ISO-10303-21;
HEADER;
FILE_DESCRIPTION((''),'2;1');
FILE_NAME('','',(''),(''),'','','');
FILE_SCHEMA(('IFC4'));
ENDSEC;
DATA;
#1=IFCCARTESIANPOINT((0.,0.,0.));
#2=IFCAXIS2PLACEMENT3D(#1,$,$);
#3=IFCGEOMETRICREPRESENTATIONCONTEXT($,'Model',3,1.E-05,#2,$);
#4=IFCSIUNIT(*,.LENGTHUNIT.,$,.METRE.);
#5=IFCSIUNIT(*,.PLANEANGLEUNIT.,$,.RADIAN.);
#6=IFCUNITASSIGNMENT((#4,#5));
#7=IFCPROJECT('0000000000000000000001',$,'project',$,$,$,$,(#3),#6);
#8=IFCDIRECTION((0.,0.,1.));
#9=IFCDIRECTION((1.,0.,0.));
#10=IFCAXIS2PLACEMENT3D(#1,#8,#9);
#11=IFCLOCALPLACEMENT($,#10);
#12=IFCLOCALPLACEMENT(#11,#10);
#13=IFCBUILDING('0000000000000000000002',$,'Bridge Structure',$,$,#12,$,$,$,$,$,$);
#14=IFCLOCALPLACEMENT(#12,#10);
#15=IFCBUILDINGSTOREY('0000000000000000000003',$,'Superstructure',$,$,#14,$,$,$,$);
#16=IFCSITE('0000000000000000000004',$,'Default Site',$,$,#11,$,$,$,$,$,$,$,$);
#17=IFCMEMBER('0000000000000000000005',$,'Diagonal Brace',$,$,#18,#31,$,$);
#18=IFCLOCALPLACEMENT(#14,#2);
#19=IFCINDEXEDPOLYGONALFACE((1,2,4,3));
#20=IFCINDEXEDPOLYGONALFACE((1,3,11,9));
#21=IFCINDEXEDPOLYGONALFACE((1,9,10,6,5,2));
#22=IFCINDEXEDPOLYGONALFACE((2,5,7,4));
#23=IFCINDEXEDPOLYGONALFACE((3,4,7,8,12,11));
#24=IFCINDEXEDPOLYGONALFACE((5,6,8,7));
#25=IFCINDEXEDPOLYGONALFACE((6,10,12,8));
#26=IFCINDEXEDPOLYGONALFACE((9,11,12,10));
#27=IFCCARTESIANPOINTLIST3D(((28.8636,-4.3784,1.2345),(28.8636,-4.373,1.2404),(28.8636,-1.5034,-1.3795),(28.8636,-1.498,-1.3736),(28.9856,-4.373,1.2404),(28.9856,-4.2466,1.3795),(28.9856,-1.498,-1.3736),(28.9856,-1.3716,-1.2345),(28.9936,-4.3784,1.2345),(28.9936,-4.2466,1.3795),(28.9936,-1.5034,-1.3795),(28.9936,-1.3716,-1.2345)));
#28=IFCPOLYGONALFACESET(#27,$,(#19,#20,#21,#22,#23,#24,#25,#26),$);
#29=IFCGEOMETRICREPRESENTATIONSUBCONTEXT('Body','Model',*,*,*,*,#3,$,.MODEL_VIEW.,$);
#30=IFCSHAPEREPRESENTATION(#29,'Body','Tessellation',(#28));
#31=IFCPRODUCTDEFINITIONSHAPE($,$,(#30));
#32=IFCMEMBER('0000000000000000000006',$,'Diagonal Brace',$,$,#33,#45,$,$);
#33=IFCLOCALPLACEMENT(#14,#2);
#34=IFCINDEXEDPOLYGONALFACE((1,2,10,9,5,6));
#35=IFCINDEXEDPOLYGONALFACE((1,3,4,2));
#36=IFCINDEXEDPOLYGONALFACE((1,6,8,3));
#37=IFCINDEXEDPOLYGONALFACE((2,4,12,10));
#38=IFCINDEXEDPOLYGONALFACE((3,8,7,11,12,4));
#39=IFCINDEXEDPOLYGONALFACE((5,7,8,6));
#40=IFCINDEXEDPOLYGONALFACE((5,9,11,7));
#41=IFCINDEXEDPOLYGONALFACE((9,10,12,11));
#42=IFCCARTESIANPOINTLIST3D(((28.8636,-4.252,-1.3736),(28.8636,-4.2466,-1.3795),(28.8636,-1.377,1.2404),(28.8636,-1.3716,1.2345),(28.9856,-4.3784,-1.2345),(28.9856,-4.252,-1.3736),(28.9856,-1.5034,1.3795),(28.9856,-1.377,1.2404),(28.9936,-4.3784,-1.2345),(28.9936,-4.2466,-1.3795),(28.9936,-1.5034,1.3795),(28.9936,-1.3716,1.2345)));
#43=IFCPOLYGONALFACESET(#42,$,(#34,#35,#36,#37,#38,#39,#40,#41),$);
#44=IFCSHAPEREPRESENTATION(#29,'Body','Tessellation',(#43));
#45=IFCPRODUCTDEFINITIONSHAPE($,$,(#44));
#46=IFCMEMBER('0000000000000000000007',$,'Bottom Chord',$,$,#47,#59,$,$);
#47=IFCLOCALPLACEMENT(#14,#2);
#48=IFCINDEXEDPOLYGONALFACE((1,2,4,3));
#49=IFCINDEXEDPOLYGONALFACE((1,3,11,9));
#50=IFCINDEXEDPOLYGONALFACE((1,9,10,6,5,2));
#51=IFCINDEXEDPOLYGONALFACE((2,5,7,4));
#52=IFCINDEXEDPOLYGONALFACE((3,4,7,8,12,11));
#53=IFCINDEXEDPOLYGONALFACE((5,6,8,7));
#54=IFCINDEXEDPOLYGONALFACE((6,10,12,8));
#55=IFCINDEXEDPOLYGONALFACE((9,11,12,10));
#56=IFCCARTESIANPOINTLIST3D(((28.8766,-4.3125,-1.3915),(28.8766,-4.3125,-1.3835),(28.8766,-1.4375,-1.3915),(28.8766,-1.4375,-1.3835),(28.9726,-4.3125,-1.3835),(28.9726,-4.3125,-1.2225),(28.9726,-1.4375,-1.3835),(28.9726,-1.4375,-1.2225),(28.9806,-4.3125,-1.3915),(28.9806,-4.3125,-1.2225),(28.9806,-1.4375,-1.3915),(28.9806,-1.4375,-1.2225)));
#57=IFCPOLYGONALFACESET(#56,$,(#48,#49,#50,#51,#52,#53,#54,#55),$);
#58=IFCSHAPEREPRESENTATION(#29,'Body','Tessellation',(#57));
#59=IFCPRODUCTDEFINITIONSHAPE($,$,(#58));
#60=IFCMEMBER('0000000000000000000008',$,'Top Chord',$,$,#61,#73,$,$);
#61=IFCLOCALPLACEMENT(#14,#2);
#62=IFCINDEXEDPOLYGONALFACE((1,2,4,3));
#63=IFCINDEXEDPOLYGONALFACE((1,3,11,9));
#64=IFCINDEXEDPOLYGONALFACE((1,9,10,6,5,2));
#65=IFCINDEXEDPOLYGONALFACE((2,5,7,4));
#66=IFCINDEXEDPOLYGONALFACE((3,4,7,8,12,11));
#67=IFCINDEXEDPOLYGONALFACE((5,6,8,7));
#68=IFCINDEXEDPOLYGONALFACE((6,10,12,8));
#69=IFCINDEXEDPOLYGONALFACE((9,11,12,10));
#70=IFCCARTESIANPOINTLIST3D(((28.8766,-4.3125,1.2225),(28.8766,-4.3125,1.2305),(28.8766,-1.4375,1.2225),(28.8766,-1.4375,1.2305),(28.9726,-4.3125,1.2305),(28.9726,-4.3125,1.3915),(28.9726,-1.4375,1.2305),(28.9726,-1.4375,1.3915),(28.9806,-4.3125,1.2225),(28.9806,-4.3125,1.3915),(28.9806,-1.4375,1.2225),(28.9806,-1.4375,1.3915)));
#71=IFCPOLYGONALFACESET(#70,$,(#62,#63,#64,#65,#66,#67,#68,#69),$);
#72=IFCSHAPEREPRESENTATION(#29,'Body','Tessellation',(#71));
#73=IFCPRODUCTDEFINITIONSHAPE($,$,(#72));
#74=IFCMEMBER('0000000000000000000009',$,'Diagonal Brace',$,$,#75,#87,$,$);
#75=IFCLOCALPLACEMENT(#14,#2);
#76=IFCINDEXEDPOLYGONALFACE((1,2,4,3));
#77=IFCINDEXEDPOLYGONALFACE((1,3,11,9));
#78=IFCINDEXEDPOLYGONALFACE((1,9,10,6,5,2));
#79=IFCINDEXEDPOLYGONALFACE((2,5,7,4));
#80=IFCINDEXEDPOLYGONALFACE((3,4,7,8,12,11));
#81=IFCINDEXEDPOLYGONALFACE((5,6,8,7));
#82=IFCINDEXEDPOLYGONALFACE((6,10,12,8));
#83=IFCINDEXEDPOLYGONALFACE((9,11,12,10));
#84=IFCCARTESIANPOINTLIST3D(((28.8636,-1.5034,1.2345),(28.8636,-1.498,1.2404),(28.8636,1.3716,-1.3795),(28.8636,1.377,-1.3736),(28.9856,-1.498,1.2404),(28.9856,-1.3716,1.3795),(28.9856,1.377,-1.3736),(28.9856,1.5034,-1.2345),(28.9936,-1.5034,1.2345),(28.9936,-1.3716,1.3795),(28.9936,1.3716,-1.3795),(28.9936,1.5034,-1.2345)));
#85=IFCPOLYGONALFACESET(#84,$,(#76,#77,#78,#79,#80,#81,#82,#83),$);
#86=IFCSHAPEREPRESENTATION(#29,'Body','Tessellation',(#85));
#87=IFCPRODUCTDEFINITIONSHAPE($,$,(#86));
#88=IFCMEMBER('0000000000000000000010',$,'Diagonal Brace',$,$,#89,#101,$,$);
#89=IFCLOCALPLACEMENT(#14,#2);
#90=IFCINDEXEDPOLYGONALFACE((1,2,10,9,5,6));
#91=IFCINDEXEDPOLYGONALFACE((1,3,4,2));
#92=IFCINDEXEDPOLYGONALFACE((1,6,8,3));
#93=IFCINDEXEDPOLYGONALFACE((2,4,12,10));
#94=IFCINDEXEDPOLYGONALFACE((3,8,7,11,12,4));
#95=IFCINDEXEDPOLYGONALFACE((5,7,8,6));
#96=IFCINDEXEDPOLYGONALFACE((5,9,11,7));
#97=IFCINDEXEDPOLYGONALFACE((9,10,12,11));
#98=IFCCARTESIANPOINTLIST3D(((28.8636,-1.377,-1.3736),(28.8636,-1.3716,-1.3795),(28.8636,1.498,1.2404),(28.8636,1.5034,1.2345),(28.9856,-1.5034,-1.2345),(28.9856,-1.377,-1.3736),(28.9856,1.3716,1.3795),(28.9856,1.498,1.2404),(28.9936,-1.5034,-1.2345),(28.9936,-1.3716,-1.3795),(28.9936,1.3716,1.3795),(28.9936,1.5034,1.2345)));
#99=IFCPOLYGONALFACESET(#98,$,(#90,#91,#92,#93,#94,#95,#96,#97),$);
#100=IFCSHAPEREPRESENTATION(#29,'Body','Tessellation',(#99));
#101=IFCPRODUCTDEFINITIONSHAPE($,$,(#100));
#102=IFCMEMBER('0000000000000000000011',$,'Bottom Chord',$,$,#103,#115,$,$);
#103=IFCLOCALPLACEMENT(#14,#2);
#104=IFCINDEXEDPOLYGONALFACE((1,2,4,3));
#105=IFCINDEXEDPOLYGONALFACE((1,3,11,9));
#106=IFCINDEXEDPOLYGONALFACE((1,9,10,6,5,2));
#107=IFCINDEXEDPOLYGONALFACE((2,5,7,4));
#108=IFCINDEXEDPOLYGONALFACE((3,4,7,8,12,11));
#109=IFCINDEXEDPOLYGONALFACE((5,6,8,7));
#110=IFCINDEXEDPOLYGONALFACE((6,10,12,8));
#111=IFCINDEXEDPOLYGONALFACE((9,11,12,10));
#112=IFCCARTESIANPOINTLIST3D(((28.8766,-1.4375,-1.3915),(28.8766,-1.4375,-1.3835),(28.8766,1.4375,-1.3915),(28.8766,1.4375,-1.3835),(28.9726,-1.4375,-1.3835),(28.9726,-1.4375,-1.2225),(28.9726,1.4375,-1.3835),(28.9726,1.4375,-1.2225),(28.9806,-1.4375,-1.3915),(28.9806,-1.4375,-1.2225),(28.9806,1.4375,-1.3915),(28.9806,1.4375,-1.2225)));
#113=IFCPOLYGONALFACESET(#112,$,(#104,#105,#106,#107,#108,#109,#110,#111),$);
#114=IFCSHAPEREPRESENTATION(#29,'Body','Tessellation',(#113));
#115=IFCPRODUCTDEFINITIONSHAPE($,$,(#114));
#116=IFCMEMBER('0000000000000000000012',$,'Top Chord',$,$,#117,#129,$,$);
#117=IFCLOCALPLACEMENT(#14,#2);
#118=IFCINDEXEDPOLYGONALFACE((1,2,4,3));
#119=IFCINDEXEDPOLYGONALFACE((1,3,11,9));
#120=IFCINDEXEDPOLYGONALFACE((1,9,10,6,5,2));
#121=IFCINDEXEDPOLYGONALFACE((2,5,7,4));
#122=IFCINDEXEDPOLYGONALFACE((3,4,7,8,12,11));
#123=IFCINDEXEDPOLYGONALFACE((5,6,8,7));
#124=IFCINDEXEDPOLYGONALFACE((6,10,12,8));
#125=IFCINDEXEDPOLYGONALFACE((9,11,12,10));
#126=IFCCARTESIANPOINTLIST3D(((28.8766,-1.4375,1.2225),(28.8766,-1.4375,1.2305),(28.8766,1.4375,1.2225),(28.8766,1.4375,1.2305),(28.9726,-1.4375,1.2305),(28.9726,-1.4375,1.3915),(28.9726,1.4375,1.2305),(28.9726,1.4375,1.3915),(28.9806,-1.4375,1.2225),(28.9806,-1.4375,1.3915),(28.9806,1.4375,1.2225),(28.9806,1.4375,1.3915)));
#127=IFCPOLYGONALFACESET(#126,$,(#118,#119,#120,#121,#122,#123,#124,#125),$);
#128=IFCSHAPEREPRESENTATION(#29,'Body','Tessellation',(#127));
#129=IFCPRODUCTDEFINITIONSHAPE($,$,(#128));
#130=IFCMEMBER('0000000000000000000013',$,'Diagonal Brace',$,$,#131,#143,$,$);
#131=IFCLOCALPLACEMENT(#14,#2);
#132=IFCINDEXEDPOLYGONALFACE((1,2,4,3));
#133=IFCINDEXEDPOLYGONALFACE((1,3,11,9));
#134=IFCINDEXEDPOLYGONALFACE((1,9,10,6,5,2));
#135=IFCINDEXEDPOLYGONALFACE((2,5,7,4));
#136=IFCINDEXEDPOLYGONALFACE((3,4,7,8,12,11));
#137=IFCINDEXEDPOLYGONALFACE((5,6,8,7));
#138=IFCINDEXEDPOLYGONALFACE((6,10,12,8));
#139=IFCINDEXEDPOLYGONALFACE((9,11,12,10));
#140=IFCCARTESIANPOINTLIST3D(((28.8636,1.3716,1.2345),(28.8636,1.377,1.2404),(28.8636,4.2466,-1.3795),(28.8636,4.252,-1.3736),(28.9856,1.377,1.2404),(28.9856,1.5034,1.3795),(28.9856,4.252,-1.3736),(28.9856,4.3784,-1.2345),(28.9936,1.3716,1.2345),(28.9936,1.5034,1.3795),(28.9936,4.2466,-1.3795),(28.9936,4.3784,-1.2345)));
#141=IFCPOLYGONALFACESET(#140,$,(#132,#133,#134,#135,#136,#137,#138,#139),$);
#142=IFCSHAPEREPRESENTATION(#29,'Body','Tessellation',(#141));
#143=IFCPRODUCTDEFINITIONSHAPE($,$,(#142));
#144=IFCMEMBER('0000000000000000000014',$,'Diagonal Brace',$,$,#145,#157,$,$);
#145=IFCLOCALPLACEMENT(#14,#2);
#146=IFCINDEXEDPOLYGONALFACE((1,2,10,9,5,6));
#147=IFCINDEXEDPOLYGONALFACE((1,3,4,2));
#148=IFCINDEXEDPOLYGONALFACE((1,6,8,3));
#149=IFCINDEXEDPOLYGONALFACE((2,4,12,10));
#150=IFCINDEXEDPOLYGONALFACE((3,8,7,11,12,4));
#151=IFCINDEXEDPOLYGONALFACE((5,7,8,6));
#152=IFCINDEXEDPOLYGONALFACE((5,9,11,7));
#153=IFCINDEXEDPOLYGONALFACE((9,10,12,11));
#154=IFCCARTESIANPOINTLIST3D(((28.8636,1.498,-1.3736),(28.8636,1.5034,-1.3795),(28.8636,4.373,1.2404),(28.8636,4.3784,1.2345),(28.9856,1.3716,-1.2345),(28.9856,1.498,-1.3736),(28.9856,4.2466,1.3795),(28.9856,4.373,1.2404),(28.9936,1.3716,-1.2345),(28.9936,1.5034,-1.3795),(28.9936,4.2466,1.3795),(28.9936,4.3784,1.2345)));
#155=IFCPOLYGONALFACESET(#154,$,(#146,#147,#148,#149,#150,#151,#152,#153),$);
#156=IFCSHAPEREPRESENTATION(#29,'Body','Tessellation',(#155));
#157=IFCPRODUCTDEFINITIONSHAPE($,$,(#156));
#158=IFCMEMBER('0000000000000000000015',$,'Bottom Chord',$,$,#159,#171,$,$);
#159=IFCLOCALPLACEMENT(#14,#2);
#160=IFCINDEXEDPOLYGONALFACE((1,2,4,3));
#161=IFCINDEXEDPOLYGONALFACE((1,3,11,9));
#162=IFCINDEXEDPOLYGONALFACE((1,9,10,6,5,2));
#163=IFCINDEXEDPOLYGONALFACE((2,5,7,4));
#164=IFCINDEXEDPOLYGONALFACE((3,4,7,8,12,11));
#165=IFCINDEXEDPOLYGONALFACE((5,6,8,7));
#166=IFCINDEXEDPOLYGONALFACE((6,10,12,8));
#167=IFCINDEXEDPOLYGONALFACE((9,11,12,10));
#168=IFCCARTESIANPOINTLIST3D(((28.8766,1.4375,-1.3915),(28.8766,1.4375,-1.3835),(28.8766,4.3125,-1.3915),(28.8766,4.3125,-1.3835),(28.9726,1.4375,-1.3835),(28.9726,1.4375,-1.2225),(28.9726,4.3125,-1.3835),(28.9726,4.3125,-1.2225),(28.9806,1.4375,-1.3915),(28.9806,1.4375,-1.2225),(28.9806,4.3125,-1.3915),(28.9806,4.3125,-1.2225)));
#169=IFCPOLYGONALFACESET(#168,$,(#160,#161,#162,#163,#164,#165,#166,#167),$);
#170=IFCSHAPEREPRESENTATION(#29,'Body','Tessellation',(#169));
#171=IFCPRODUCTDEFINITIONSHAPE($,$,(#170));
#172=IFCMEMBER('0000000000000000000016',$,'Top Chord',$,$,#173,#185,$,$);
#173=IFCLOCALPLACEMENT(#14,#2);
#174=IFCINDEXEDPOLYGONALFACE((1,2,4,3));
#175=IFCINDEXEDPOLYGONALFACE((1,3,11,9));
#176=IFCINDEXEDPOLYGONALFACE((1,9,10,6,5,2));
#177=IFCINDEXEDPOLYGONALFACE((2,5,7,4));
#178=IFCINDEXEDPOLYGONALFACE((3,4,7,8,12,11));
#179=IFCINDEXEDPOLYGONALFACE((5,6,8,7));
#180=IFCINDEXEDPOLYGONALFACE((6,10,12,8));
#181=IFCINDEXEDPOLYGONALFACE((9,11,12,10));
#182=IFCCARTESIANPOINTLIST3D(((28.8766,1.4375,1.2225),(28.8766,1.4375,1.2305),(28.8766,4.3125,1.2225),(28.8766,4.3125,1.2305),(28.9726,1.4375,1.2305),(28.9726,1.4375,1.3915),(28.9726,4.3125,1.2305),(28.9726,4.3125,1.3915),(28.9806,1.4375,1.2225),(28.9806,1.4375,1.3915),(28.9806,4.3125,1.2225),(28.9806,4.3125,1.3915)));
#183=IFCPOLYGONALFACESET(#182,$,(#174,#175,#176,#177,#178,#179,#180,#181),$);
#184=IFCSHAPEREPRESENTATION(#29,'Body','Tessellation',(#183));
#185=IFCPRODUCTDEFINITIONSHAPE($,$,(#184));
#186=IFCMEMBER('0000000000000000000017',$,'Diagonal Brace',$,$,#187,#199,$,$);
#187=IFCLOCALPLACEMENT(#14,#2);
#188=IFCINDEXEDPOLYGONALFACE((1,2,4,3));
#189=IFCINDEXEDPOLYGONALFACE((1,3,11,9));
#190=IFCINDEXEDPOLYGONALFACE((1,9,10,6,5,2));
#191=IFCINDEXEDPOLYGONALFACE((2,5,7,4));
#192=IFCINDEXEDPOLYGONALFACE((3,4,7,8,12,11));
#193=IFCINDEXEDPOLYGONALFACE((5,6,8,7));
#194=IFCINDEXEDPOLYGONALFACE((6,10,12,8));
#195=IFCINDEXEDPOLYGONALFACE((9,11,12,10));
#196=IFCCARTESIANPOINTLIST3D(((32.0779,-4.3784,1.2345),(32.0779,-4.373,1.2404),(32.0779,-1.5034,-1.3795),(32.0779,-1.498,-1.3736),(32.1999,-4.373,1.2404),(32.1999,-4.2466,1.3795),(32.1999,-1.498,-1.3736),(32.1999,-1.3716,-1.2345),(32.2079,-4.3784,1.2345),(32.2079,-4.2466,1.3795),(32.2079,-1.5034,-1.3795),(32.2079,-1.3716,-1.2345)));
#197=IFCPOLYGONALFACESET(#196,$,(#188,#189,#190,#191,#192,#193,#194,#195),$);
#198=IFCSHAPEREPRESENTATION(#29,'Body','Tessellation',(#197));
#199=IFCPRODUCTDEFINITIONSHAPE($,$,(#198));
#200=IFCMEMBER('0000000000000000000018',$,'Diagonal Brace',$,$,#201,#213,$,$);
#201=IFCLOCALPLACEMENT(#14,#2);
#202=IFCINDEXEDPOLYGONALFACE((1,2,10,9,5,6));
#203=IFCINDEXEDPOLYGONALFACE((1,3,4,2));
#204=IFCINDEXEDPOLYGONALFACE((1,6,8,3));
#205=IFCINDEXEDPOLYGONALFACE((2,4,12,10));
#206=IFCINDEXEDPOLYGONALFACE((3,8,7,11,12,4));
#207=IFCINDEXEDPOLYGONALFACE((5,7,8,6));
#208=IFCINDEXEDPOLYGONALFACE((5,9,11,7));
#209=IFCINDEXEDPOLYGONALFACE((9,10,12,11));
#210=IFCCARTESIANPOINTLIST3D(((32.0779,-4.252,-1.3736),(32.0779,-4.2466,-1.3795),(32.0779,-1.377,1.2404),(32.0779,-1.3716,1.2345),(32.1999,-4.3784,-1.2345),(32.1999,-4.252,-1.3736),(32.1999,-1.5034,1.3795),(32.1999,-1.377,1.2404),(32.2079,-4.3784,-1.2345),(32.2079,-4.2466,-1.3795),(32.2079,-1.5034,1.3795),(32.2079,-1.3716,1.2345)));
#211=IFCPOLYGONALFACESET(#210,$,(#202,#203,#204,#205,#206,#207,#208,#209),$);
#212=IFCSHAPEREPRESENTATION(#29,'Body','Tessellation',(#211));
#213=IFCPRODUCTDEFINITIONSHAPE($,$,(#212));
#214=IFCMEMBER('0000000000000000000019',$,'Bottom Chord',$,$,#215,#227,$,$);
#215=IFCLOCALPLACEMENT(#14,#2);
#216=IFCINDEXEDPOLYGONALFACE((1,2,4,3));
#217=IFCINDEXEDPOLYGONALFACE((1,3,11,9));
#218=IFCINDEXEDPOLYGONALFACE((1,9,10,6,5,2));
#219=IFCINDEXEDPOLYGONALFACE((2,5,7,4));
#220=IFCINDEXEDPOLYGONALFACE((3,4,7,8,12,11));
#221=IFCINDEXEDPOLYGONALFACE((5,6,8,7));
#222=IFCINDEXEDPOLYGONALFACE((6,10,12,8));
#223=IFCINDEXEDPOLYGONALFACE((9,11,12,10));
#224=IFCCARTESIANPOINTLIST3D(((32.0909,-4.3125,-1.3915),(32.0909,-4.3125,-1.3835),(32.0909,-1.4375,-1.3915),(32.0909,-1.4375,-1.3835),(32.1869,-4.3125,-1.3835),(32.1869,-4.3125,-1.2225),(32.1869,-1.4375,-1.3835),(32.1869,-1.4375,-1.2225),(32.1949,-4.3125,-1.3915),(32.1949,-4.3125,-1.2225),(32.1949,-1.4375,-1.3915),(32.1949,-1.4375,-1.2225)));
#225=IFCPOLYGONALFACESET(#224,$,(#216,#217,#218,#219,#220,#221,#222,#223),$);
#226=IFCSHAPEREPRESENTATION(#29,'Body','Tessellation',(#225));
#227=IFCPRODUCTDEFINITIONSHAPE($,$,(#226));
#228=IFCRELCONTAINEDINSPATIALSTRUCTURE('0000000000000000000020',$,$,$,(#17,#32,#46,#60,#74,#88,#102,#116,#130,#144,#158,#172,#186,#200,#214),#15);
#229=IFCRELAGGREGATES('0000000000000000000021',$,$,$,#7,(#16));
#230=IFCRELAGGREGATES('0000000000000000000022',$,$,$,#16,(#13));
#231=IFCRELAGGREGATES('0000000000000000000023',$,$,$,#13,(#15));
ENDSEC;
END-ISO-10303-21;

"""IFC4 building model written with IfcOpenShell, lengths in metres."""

from ifc_helpers import new_model, si_unit, frame, origin, origin_with_axes, origin_2d_with_axis, place, context, subcontext, project, spatial, l_section, extrude, element, save


model = new_model("IFC4")

# Units and contexts
model_context = context("Model", 3, precision=1e-05, world=origin())
body_context = subcontext(model_context, "Body", "Model", "MODEL_VIEW")
ifc_project = project(units=[si_unit("LENGTHUNIT", "METRE"), si_unit("PLANEANGLEUNIT", "RADIAN")], contexts=[model_context])

# Site, building, storey
site_placement = place(None, origin_with_axes())
site = spatial("IfcSite", under=ifc_project, at=site_placement, Name="Default Site")
building_placement = place(site_placement, origin_with_axes())
building = spatial("IfcBuilding", under=site, at=building_placement, Name="Bridge Structure")
storey_placement = place(building_placement, origin_with_axes())
storey = spatial("IfcBuildingStorey", under=building, at=storey_placement, Name="Superstructure")

# Members
for number, where, z_axis, x_axis, name in (
    (1, (28.9286, -4.3125, 1.307), (0.0, 0.739893, -0.672724), (-1.0, 0.0, 0.0), "Diagonal Brace"),
    (2, (28.9286, -4.3125, -1.307), (0.0, 0.739893, 0.672724), (-1.0, 0.0, 0.0), "Diagonal Brace"),
):
    element("IfcMember", number, at=place(storey_placement, frame(where, z_axis=z_axis, x_axis=x_axis)), inside=storey, Name=name, context=body_context, shape_type="SweptSolid", body=[
        extrude(l_section(Depth=0.196, Width=0.13, Thickness=0.008, at=origin_2d_with_axis()), origin_with_axes(), (0.0, 0.0, 1.0), 3.8857),
    ])
for number, where, z_axis, x_axis, name in (
    (3, (28.9286, -4.3125, -1.307), (0.0, 1.0, 0.0), (-1.0, 0.0, 0.0), "Bottom Chord"),
    (4, (28.9286, -4.3125, 1.307), (0.0, 1.0, 0.0), (-1.0, 0.0, 0.0), "Top Chord"),
):
    element("IfcMember", number, at=place(storey_placement, frame(where, z_axis=z_axis, x_axis=x_axis)), inside=storey, Name=name, context=body_context, shape_type="SweptSolid", body=[
        extrude(l_section(Depth=0.169, Width=0.104, Thickness=0.008, at=origin_2d_with_axis()), origin_with_axes(), (0.0, 0.0, 1.0), 2.875),
    ])
for number, where, z_axis, x_axis, name in (
    (5, (28.9286, -1.4375, 1.307), (0.0, 0.739893, -0.672724), (-1.0, 0.0, 0.0), "Diagonal Brace"),
    (6, (28.9286, -1.4375, -1.307), (0.0, 0.739893, 0.672724), (-1.0, 0.0, 0.0), "Diagonal Brace"),
):
    element("IfcMember", number, at=place(storey_placement, frame(where, z_axis=z_axis, x_axis=x_axis)), inside=storey, Name=name, context=body_context, shape_type="SweptSolid", body=[
        extrude(l_section(Depth=0.196, Width=0.13, Thickness=0.008, at=origin_2d_with_axis()), origin_with_axes(), (0.0, 0.0, 1.0), 3.8857),
    ])
for number, where, z_axis, x_axis, name in (
    (7, (28.9286, -1.4375, -1.307), (0.0, 1.0, 0.0), (-1.0, 0.0, 0.0), "Bottom Chord"),
    (8, (28.9286, -1.4375, 1.307), (0.0, 1.0, 0.0), (-1.0, 0.0, 0.0), "Top Chord"),
):
    element("IfcMember", number, at=place(storey_placement, frame(where, z_axis=z_axis, x_axis=x_axis)), inside=storey, Name=name, context=body_context, shape_type="SweptSolid", body=[
        extrude(l_section(Depth=0.169, Width=0.104, Thickness=0.008, at=origin_2d_with_axis()), origin_with_axes(), (0.0, 0.0, 1.0), 2.875),
    ])
for number, where, z_axis, x_axis, name in (
    (9, (28.9286, 1.4375, 1.307), (0.0, 0.739893, -0.672724), (-1.0, 0.0, 0.0), "Diagonal Brace"),
    (10, (28.9286, 1.4375, -1.307), (0.0, 0.739893, 0.672724), (-1.0, 0.0, 0.0), "Diagonal Brace"),
):
    element("IfcMember", number, at=place(storey_placement, frame(where, z_axis=z_axis, x_axis=x_axis)), inside=storey, Name=name, context=body_context, shape_type="SweptSolid", body=[
        extrude(l_section(Depth=0.196, Width=0.13, Thickness=0.008, at=origin_2d_with_axis()), origin_with_axes(), (0.0, 0.0, 1.0), 3.8857),
    ])
for number, where, z_axis, x_axis, name in (
    (11, (28.9286, 1.4375, -1.307), (0.0, 1.0, 0.0), (-1.0, 0.0, 0.0), "Bottom Chord"),
    (12, (28.9286, 1.4375, 1.307), (0.0, 1.0, 0.0), (-1.0, 0.0, 0.0), "Top Chord"),
):
    element("IfcMember", number, at=place(storey_placement, frame(where, z_axis=z_axis, x_axis=x_axis)), inside=storey, Name=name, context=body_context, shape_type="SweptSolid", body=[
        extrude(l_section(Depth=0.169, Width=0.104, Thickness=0.008, at=origin_2d_with_axis()), origin_with_axes(), (0.0, 0.0, 1.0), 2.875),
    ])
for number, where, z_axis, x_axis, name in (
    (13, (32.1429, -4.3125, 1.307), (0.0, 0.739893, -0.672724), (-1.0, 0.0, 0.0), "Diagonal Brace"),
    (14, (32.1429, -4.3125, -1.307), (0.0, 0.739893, 0.672724), (-1.0, 0.0, 0.0), "Diagonal Brace"),
):
    element("IfcMember", number, at=place(storey_placement, frame(where, z_axis=z_axis, x_axis=x_axis)), inside=storey, Name=name, context=body_context, shape_type="SweptSolid", body=[
        extrude(l_section(Depth=0.196, Width=0.13, Thickness=0.008, at=origin_2d_with_axis()), origin_with_axes(), (0.0, 0.0, 1.0), 3.8857),
    ])
for number, where, z_axis, x_axis, name in (
    (15, (32.1429, -4.3125, -1.307), (0.0, 1.0, 0.0), (-1.0, 0.0, 0.0), "Bottom Chord"),
):
    element("IfcMember", number, at=place(storey_placement, frame(where, z_axis=z_axis, x_axis=x_axis)), inside=storey, Name=name, context=body_context, shape_type="SweptSolid", body=[
        extrude(l_section(Depth=0.169, Width=0.104, Thickness=0.008, at=origin_2d_with_axis()), origin_with_axes(), (0.0, 0.0, 1.0), 2.875),
    ])

save(model, "model.ifc")
